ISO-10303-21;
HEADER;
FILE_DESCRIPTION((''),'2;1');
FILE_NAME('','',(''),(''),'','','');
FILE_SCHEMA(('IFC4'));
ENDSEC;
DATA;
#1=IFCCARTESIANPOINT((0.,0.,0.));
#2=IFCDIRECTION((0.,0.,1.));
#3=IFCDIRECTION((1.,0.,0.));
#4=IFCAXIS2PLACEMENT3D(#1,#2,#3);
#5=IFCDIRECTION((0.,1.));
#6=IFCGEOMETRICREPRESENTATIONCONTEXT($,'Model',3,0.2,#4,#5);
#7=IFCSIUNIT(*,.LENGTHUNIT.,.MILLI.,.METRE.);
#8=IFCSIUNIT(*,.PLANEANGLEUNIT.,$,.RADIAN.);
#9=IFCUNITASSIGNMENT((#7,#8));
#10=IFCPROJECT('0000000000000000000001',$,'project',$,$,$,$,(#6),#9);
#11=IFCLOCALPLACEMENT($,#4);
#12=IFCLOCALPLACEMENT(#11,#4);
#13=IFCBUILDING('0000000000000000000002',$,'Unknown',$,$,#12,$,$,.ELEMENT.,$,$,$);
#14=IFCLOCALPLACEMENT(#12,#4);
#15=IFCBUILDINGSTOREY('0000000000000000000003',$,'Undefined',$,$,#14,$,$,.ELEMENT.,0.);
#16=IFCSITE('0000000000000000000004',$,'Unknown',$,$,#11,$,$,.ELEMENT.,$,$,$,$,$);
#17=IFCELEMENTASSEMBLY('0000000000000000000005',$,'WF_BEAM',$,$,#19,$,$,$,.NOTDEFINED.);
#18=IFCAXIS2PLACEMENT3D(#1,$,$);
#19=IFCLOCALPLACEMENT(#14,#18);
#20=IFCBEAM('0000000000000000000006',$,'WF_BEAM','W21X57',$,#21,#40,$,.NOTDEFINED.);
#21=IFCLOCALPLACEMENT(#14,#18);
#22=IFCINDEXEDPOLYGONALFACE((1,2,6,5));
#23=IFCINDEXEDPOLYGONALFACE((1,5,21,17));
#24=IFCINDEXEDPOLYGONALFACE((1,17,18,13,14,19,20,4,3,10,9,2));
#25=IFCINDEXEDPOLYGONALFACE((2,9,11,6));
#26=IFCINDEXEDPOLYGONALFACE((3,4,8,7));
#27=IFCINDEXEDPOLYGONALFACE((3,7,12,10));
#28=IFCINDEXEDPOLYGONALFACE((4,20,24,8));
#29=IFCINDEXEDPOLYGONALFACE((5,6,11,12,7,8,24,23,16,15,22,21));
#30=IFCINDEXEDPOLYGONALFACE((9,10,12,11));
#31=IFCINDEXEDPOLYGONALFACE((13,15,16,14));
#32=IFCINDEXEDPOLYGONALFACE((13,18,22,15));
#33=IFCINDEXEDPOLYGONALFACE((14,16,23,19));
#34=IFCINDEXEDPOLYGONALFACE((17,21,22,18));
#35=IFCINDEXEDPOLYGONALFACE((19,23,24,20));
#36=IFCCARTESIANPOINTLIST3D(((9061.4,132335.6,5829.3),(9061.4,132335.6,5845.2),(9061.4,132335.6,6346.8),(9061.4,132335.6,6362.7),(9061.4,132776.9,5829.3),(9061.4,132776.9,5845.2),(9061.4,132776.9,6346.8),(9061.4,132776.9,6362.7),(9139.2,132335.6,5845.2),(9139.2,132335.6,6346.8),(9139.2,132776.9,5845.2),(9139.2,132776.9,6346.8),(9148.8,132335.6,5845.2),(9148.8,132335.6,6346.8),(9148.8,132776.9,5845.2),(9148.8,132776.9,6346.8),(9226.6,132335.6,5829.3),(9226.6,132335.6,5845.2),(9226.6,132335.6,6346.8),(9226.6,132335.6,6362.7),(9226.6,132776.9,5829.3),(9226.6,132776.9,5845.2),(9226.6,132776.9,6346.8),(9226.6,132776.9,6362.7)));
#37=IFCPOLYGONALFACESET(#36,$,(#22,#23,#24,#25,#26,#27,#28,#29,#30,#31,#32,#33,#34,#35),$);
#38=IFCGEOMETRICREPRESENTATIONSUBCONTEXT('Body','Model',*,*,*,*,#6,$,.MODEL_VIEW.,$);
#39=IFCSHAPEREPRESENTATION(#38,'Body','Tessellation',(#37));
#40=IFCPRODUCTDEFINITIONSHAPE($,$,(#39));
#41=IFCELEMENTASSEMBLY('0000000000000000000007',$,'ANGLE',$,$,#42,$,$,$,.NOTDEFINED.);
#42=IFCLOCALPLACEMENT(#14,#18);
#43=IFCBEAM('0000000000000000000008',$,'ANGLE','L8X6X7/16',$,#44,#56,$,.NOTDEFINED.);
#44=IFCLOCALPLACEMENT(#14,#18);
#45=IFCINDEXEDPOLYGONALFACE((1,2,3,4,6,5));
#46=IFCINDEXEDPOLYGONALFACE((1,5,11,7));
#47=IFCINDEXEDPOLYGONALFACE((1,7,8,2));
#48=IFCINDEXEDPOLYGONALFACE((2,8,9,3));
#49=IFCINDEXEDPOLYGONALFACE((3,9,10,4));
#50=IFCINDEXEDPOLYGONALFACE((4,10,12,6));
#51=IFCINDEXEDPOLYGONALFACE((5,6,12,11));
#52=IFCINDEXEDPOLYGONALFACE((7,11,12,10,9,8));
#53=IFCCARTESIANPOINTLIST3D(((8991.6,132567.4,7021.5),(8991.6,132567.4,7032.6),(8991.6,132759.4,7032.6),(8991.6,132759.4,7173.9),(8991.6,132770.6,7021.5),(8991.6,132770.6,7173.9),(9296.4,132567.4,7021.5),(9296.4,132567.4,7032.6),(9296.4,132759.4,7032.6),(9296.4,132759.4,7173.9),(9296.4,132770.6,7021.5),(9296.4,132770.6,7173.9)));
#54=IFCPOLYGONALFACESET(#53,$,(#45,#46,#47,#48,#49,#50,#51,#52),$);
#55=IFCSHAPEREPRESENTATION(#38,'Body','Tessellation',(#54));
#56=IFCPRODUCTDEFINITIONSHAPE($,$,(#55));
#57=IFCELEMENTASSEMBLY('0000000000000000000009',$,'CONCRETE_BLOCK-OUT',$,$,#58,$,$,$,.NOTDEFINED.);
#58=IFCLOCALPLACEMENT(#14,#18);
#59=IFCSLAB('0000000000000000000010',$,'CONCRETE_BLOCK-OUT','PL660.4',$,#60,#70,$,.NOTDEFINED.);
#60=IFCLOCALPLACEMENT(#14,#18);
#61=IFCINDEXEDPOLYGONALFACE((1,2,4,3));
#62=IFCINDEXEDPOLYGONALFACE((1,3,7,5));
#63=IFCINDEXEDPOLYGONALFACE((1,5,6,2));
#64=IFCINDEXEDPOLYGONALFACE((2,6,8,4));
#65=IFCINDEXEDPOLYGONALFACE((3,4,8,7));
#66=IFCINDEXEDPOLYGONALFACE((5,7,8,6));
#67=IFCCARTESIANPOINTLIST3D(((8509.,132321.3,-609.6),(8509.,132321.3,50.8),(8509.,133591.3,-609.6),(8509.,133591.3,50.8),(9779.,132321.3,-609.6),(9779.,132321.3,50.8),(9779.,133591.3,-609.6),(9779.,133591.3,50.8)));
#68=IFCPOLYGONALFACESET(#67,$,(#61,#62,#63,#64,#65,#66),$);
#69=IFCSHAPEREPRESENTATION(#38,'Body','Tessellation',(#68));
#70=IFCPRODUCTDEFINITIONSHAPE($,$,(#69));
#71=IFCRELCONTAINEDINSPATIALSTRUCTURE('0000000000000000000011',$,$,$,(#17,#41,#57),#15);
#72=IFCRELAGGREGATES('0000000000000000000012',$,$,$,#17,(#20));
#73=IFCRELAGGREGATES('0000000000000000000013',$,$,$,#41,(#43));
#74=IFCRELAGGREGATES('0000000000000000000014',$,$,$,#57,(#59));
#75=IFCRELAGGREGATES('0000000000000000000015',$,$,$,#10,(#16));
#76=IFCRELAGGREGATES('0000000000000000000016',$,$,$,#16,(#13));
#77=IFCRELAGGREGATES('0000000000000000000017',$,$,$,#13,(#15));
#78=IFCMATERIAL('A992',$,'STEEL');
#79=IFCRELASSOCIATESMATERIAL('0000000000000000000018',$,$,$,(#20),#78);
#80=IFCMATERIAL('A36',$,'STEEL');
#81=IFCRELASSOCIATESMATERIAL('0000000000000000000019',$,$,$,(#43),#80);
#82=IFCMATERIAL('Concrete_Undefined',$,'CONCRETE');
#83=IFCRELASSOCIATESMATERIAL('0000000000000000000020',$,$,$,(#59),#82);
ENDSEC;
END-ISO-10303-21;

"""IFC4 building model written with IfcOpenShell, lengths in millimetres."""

from ifc_helpers import new_model, si_unit, direction, frame, origin_with_axes, place, context, subcontext, project, spatial, line, indexed_curve, outline, extrude, material, element, aggregate, save


model = new_model("IFC4")

# Units and contexts
model_context = context("Model", 3, precision=0.2, world=origin_with_axes(), true_north=direction((0.0, 1.0)))
body_context = subcontext(model_context, "Body", "Model", "MODEL_VIEW")
ifc_project = project(units=[si_unit("LENGTHUNIT", "METRE", prefix="MILLI"), si_unit("PLANEANGLEUNIT", "RADIAN")], contexts=[model_context])

# Site, building, storey
site_placement = place(None, origin_with_axes())
site = spatial("IfcSite", under=ifc_project, at=site_placement, Name="Unknown", CompositionType="ELEMENT")
building_placement = place(site_placement, origin_with_axes())
building = spatial("IfcBuilding", under=site, at=building_placement, Name="Unknown", CompositionType="ELEMENT")
storey_placement = place(building_placement, origin_with_axes())
storey = spatial("IfcBuildingStorey", under=building, at=storey_placement, Name="Undefined", CompositionType="ELEMENT", Elevation=0.0)

# Shared definitions
ifc_material_1 = material(Name="A992", Category="STEEL")

# Element assemblies, beams
ifc_material_2 = material(Name="A36", Category="STEEL")
assembly_1_placement = place(storey_placement, frame((9144.0, 132335.6, 6096.0), z_axis=(1.0, 0.0, 0.0), x_axis=(0.0, 1.0, 0.0)))
assembly_1 = element("IfcElementAssembly", 1, at=assembly_1_placement, inside=storey, Name="WF_BEAM", PredefinedType="NOTDEFINED")
beam_1_placement = place(assembly_1_placement, origin_with_axes())
beam_1 = element("IfcBeam", 2, at=beam_1_placement, material=ifc_material_1, Name="WF_BEAM", Description="W21X57", PredefinedType="NOTDEFINED", context=body_context, shape_type="SolidModel", body=[
    extrude(outline(indexed_curve([(-82.5, -266.7), (82.5, -266.7), (82.5, -250.8), (4.8, -250.8), (4.8, 250.8), (82.5, 250.8), (82.5, 266.7), (-82.5, 266.7), (-82.5, 250.8), (-4.8, 250.8), (-4.8, -250.8), (-82.5, -250.8)], segments=[line(1, 2, 3, 4, 5, 6, 7, 8, 9, 10, 11, 12, 1)])), frame((0.0, 0.0, 0.0), z_axis=(-1.0, 0.0, 0.0), x_axis=(0.0, 0.0, 1.0)), (0.0, 0.0, -1.0), 441.3),
])
aggregate(assembly_1, [beam_1])
assembly_2_placement = place(storey_placement, frame((9296.4, 132669.0, 7097.7), z_axis=(0.0, 0.0, 1.0), x_axis=(-1.0, 0.000019, 0.0)))
assembly_2 = element("IfcElementAssembly", 3, at=assembly_2_placement, inside=storey, Name="ANGLE", PredefinedType="NOTDEFINED")
beam_2_placement = place(assembly_2_placement, origin_with_axes())
beam_2 = element("IfcBeam", 4, at=beam_2_placement, material=ifc_material_2, Name="ANGLE", Description="L8X6X7/16", PredefinedType="NOTDEFINED", context=body_context, shape_type="SolidModel", body=[
    extrude(outline(indexed_curve([(-76.2, -101.6), (76.2, -101.6), (76.2, -90.5), (-65.1, -90.5), (-65.1, 101.6), (-76.2, 101.6)], segments=[line(1, 2, 3, 4, 5, 6, 1)])), frame((0.0, 0.0, 0.0), z_axis=(-1.0, 0.0, 0.0), x_axis=(0.0, 0.0, 1.0)), (0.0, 0.0, -1.0), 304.8),
])
aggregate(assembly_2, [beam_2])

# Element assembly, slab
assembly_3_placement = place(storey_placement, frame((9779.0, 133591.3, -279.4), z_axis=(0.0, 0.0, 1.0), x_axis=(-1.0, 0.0, 0.0)))
assembly_3 = element("IfcElementAssembly", 5, at=assembly_3_placement, inside=storey, Name="CONCRETE_BLOCK-OUT", PredefinedType="NOTDEFINED")
ifc_material_3 = material(Name="Concrete_Undefined", Category="CONCRETE")
slab_placement = place(assembly_3_placement, origin_with_axes())
slab = element("IfcSlab", 6, at=slab_placement, material=ifc_material_3, Name="CONCRETE_BLOCK-OUT", Description="PL660.4", PredefinedType="NOTDEFINED", context=body_context, shape_type="SolidModel", body=[
    extrude(outline(indexed_curve([(0.0, 0.0), (1270.0, 0.0), (1270.0, 1270.0), (0.0, 1270.0)], segments=[line(1, 2, 3, 4, 1)])), frame((0.0, 0.0, 330.2), z_axis=(0.0, 0.0, 1.0), x_axis=(1.0, 0.0, 0.0)), (0.0, 0.0, -1.0), 660.4),
])
aggregate(assembly_3, [slab])

save(model, "model.ifc")
